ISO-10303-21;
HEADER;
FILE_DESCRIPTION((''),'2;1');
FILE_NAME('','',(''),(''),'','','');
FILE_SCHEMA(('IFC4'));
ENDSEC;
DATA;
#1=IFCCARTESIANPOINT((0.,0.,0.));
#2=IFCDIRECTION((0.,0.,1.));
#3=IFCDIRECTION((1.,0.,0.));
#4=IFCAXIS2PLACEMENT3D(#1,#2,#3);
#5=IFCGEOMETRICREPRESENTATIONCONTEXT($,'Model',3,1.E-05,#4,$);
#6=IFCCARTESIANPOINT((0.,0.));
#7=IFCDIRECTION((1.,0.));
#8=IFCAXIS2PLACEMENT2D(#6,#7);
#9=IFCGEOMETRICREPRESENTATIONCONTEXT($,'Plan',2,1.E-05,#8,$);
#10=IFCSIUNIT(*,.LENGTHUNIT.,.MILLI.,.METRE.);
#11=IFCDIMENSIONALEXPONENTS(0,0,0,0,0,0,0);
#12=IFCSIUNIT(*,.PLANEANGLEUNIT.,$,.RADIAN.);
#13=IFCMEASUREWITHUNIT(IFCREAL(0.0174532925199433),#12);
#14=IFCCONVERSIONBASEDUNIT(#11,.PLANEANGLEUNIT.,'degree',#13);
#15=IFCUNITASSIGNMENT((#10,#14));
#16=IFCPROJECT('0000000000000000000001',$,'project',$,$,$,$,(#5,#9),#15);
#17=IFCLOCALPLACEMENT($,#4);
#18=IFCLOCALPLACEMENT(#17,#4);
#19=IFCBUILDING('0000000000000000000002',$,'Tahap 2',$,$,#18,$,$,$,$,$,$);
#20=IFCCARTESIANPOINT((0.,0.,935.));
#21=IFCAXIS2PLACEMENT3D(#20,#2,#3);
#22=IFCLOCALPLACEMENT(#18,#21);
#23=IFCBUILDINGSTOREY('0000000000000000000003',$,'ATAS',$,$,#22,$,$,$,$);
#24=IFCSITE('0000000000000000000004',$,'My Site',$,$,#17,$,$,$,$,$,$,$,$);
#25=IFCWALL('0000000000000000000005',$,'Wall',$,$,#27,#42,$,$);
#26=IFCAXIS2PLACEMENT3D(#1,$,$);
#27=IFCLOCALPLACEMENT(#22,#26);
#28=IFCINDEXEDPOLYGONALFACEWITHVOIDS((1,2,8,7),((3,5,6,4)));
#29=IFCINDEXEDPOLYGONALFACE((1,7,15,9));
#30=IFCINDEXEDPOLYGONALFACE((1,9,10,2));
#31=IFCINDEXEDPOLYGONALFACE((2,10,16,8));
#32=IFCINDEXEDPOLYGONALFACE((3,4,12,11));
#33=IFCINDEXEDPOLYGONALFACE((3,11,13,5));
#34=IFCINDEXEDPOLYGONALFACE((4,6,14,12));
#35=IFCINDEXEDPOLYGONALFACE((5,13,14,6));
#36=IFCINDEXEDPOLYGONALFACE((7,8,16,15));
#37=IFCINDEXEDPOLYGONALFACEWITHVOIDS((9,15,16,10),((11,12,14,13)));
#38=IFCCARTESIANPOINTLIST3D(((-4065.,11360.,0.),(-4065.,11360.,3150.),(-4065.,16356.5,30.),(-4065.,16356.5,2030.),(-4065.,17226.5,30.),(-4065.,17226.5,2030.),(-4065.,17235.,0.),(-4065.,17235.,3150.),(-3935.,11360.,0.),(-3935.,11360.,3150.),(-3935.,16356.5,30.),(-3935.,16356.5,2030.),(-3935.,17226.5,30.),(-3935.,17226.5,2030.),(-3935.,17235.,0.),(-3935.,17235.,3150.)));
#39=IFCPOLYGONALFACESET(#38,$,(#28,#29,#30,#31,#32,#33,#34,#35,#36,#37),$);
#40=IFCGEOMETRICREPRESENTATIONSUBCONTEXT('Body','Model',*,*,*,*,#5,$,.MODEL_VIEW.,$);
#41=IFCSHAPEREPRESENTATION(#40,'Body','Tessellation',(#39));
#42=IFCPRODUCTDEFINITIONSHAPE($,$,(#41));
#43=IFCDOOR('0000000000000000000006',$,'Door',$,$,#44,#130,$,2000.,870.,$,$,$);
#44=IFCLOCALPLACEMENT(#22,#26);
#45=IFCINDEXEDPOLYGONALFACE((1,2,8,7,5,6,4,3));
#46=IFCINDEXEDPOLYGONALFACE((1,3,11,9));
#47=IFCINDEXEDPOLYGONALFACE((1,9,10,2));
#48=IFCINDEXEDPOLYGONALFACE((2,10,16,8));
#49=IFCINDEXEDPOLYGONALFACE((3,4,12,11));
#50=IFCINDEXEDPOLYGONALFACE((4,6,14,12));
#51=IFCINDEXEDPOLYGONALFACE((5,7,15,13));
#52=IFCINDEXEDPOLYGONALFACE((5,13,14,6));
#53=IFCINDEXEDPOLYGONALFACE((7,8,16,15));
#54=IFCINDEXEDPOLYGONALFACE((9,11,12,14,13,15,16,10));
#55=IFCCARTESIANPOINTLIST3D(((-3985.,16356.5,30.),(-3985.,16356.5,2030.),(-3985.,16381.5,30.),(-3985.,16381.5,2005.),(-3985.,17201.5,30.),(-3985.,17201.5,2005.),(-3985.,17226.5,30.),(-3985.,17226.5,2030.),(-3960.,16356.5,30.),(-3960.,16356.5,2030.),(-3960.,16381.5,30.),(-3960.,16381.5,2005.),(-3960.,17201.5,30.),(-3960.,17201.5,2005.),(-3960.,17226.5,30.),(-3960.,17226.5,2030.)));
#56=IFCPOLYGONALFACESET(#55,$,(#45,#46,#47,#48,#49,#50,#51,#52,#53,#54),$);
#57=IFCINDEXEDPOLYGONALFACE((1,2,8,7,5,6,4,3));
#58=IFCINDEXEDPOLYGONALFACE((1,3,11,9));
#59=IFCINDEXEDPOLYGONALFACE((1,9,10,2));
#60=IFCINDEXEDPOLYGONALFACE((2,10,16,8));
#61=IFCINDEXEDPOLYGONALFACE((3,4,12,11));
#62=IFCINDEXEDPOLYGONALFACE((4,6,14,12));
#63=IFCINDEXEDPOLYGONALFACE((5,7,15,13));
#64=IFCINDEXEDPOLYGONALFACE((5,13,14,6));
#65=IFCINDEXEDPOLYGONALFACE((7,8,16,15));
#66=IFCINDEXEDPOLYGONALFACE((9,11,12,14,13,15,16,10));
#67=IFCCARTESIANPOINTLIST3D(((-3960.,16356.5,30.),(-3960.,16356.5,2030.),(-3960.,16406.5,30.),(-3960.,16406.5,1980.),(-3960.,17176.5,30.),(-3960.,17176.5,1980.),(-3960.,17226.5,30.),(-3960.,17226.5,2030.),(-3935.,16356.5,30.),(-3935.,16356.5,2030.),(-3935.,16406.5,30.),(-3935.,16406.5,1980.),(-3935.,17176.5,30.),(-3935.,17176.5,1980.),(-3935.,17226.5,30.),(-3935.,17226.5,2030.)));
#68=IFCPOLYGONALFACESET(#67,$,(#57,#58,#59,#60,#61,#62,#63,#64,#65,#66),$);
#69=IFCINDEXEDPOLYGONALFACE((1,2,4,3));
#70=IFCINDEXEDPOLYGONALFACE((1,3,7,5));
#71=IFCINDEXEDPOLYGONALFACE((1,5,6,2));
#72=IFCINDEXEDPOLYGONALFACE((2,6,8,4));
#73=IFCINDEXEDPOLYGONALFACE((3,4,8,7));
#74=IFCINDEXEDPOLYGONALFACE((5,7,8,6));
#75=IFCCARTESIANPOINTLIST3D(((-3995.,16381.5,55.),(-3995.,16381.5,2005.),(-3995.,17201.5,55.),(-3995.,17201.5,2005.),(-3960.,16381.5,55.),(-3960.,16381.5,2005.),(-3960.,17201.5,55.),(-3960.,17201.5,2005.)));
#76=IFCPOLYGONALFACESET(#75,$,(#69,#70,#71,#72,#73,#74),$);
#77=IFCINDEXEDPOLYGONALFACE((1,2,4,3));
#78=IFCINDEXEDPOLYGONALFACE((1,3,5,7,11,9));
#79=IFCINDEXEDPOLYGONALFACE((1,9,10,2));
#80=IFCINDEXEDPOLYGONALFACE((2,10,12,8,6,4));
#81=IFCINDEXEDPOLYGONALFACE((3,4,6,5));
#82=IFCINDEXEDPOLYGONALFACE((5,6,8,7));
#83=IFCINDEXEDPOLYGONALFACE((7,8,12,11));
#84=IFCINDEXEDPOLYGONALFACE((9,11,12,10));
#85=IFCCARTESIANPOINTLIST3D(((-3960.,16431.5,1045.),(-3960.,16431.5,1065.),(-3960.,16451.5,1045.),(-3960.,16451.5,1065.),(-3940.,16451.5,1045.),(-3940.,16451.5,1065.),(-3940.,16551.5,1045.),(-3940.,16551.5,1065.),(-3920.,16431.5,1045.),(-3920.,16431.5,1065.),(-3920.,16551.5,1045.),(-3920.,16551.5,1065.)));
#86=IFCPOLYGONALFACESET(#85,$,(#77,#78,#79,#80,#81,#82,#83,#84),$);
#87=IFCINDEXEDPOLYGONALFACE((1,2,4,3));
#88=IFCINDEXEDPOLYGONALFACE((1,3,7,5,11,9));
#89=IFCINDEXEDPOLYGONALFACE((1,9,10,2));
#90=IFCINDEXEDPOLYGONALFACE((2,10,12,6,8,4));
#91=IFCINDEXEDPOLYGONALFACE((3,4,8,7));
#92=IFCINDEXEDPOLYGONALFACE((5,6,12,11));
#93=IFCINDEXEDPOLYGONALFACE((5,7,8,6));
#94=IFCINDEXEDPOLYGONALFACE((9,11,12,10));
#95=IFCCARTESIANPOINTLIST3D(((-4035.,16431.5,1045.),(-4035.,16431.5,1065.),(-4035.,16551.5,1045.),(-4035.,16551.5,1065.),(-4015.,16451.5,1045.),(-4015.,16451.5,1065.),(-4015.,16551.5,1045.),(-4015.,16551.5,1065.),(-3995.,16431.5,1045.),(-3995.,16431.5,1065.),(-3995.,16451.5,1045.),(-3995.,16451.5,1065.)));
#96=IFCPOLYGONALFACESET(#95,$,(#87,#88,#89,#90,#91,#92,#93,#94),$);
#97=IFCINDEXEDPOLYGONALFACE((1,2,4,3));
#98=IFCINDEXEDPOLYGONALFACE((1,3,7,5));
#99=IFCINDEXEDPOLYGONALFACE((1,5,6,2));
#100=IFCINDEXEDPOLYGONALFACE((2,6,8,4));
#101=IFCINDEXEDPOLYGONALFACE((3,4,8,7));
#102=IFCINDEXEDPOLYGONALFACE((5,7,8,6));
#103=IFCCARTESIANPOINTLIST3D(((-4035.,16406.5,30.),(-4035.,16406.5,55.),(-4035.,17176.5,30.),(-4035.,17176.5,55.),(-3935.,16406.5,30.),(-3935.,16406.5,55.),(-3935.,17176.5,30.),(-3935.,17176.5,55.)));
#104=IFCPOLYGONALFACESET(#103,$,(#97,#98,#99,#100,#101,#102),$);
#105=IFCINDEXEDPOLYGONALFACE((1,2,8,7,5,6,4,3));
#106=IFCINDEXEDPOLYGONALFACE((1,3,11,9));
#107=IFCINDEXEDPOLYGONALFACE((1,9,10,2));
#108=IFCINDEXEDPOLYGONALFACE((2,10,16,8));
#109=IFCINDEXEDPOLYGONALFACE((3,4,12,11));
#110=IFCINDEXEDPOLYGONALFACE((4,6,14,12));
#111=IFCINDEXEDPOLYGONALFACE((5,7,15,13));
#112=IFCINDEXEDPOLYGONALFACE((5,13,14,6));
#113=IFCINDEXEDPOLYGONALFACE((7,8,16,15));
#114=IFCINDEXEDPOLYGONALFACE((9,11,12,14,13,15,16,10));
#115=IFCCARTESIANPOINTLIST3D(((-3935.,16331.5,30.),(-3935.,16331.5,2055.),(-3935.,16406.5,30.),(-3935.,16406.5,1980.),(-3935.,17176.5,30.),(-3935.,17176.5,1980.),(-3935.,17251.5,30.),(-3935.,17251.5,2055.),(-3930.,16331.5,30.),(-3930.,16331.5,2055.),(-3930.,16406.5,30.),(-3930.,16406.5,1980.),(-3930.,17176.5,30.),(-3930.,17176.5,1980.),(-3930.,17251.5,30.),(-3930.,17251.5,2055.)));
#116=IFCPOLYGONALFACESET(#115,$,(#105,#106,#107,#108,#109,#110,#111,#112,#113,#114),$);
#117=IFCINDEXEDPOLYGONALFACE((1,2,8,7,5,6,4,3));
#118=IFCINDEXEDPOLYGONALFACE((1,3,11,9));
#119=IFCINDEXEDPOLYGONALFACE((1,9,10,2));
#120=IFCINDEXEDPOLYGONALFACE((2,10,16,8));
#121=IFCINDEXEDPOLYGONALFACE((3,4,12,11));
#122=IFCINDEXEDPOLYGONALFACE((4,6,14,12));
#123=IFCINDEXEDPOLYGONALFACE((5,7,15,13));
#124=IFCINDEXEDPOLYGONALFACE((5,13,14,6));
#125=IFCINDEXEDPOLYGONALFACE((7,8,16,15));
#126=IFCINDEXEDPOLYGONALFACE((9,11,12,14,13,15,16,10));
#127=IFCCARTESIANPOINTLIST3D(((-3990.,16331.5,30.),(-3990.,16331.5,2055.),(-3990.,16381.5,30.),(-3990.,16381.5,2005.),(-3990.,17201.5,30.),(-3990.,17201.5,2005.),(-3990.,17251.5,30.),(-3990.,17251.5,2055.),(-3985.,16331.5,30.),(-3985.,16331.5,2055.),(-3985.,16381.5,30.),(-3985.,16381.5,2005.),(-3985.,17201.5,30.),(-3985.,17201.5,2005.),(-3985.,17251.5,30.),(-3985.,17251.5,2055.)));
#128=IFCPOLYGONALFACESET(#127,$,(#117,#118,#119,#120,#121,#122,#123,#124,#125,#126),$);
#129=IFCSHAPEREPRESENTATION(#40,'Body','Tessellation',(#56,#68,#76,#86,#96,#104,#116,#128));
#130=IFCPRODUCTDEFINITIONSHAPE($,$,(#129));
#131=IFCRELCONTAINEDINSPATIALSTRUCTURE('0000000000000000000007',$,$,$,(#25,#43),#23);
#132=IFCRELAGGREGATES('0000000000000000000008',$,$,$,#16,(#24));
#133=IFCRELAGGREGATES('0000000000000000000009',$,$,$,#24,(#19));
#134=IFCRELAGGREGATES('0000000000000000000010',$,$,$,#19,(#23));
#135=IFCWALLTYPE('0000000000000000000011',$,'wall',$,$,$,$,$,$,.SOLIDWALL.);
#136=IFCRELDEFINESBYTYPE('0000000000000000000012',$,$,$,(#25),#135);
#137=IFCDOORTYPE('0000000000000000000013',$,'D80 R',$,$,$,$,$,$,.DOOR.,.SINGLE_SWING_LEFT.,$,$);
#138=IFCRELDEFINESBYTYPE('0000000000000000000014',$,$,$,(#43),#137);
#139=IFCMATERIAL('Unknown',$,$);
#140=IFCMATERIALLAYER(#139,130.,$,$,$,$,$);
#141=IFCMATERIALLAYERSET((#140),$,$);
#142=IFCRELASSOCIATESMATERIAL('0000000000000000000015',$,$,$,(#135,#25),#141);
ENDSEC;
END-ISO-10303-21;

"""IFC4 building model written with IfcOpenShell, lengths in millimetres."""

from ifc_helpers import new_model, entity, si_unit, converted_unit, frame, origin_with_axes, origin_2d_with_axis, place, context, subcontext, project, spatial, line, indexed_curve, outline, extrude, shape, source, transform, mapped, material, layer, layer_set, layer_usage, type_object, type_shapes, element, fill, save


model = new_model("IFC4")

# Units and contexts
model_context = context("Model", 3, precision=1e-05, world=origin_with_axes())
plan_context = context("Plan", 2, precision=1e-05, world=origin_2d_with_axis())
body_context_1 = subcontext(model_context, "Body", "Model", "MODEL_VIEW")
body_context_2 = subcontext(plan_context, "Body", "Plan", "PLAN_VIEW")
ifc_project = project(units=[si_unit("LENGTHUNIT", "METRE", prefix="MILLI"), converted_unit("PLANEANGLEUNIT", "degree", entity("IfcReal", 0.0174532925199433), si_unit("PLANEANGLEUNIT", "RADIAN"), dimensions=[0, 0, 0, 0, 0, 0, 0])], contexts=[model_context, plan_context])

# Site, building, storey
site_placement = place(None, origin_with_axes())
site = spatial("IfcSite", under=ifc_project, at=site_placement, Name="My Site")
building_placement = place(site_placement, origin_with_axes())
building = spatial("IfcBuilding", under=site, at=building_placement, Name="Tahap 2")
storey_placement = place(building_placement, frame((0.0, 0.0, 935.0), z_axis=(0.0, 0.0, 1.0), x_axis=(1.0, 0.0, 0.0)))
storey = spatial("IfcBuildingStorey", under=building, at=storey_placement, Name="ATAS")

# Wall, opening, door
ifc_material_1 = material(Name="Unknown")
ifc_layer_1 = layer(ifc_material_1, 130.0)
ifc_layer_set_1 = layer_set([ifc_layer_1])
ifc_layer_usage_1 = layer_usage(ifc_layer_set_1, "AXIS2", "POSITIVE", 0.0)
wall_type_1 = type_object("IfcWallType", Name="wall", PredefinedType="SOLIDWALL", material=ifc_layer_set_1)
wall_1_placement = place(storey_placement, frame((-3935.0, 11360.0, 0.0), z_axis=(0.0, 0.0, 1.0), x_axis=(0.0, 1.0, 0.0)))
wall_1 = element("IfcWall", 1, at=wall_1_placement, inside=storey, type_object=wall_type_1, material=ifc_layer_usage_1, Name="Wall", context=body_context_1, shape_type="SweptSolid", body=[
    extrude(outline(indexed_curve([(0.0, 0.0), (0.0, 130.0), (5875.0, 130.0), (5875.0, 0.0)], segments=[line(1, 2, 3, 4, 1)])), origin_with_axes(), (0.0, 0.0, 1.0), 3150.0),
])
shared_shape_1 = source(origin_with_axes(), body_context_1, "Body", "SweptSolid", [
    extrude(outline(indexed_curve([(0.0, 0.0), (870.0, 0.0), (870.0, 2000.0), (0.0, 2000.0)], segments=[line(1, 2, 3, 4, 1)])), frame((0.0, -600.0, 0.0), z_axis=(0.0, -1.0, 0.0), x_axis=(1.0, 0.0, 0.0)), (0.0, 0.0, -1.0), 1200.0),
])
opening_1_placement = place(wall_1_placement, frame((4996.5, 0.0, 30.0), z_axis=(0.0, 0.0, 1.0), x_axis=(1.0, 0.0, 0.0)))
opening_1 = element("IfcOpeningElement", 2, at=opening_1_placement, cuts=wall_1, PredefinedType="OPENING", context=body_context_1, shape_type="MappedRepresentation", body=[
    mapped(shared_shape_1, transform((0.0, 0.0, 0.0), x_axis=(1.0, 0.0, 0.0), y_axis=(0.0, 1.0, 0.0), z_axis=(0.0, 0.0, 1.0), scale=1.0)),
])
door_type_1 = type_object("IfcDoorType", Name="D80 R", OperationType="SINGLE_SWING_LEFT", PredefinedType="DOOR")
shared_shape_2 = source(origin_with_axes(), body_context_1, "Body", "SweptSolid", [
    extrude(outline(indexed_curve([(0.0, 0.0), (0.0, 2000.0), (870.0, 2000.0), (870.0, 0.0), (845.0, 0.0), (845.0, 1975.0), (25.0, 1975.0), (25.0, 0.0)], segments=[line(1, 2, 3, 4, 5, 6, 7, 8, 1)])), frame((0.0, 25.0, 0.0), z_axis=(0.0, -1.0, 0.0), x_axis=(1.0, 0.0, 0.0)), (0.0, 0.0, -1.0), 25.0),
    extrude(outline(indexed_curve([(0.0, 0.0), (0.0, 2000.0), (870.0, 2000.0), (870.0, 0.0), (820.0, 0.0), (820.0, 1950.0), (50.0, 1950.0), (50.0, 0.0)], segments=[line(1, 2, 3, 4, 5, 6, 7, 8, 1)])), frame((0.0, 0.0, 0.0), z_axis=(0.0, -1.0, 0.0), x_axis=(1.0, 0.0, 0.0)), (0.0, 0.0, -1.0), 25.0),
    extrude(outline(indexed_curve([(0.0, 0.0), (820.0, 0.0), (820.0, 35.0), (0.0, 35.0)], segments=[line(1, 2, 3, 4, 1)])), frame((25.0, 25.0, 25.0), z_axis=(0.0, 0.0, 1.0), x_axis=(1.0, 0.0, 0.0)), (0.0, 0.0, 1.0), 1950.0),
    extrude(outline(indexed_curve([(0.0, 0.0), (0.0, -40.0), (120.0, -40.0), (120.0, -20.0), (20.0, -20.0), (20.0, 0.0)], segments=[line(1, 2, 3, 4, 5, 6, 1)])), frame((75.0, 25.0, 1015.0), z_axis=(0.0, 0.0, 1.0), x_axis=(1.0, 0.0, 0.0)), (0.0, 0.0, 1.0), 20.0),
    extrude(outline(indexed_curve([(0.0, 0.0), (0.0, 40.0), (120.0, 40.0), (120.0, 20.0), (20.0, 20.0), (20.0, 0.0)], segments=[line(1, 2, 3, 4, 5, 6, 1)])), frame((75.0, 60.0, 1015.0), z_axis=(0.0, 0.0, 1.0), x_axis=(1.0, 0.0, 0.0)), (0.0, 0.0, 1.0), 20.0),
    extrude(outline(indexed_curve([(0.0, 0.0), (770.0, 0.0), (770.0, 100.0), (0.0, 100.0)], segments=[line(1, 2, 3, 4, 1)])), frame((50.0, 0.0, 0.0), z_axis=(0.0, 0.0, 1.0), x_axis=(1.0, 0.0, 0.0)), (0.0, 0.0, 1.0), 25.0),
    extrude(outline(indexed_curve([(0.0, 0.0), (0.0, 2025.0), (920.0, 2025.0), (920.0, 0.0), (845.0, 0.0), (845.0, 1950.0), (75.0, 1950.0), (75.0, 0.0)], segments=[line(1, 2, 3, 4, 5, 6, 7, 8, 1)])), frame((-25.0, -5.0, 0.0), z_axis=(0.0, -1.0, 0.0), x_axis=(1.0, 0.0, 0.0)), (0.0, 0.0, -1.0), 5.0),
    extrude(outline(indexed_curve([(0.0, 0.0), (0.0, 2025.0), (920.0, 2025.0), (920.0, 0.0), (870.0, 0.0), (870.0, 1975.0), (50.0, 1975.0), (50.0, 0.0)], segments=[line(1, 2, 3, 4, 5, 6, 7, 8, 1)])), frame((-25.0, 50.0, 0.0), z_axis=(0.0, -1.0, 0.0), x_axis=(1.0, 0.0, 0.0)), (0.0, 0.0, -1.0), 5.0),
])
shared_shape_3 = source(origin_with_axes(), body_context_2, "Body", "Curve2D", [
    entity("IfcIndexedPolyCurve", entity("IfcCartesianPointList2D", [[0.0, 0.0], [0.0, 50.0], [25.0, 50.0], [25.0, 25.0], [50.0, 25.0], [50.0, 0.0]]), [entity("IfcLineIndex", [1, 2, 3, 4, 5, 6, 1])]),
    entity("IfcIndexedPolyCurve", entity("IfcCartesianPointList2D", [[870.0, 0.0], [870.0, 50.0], [845.0, 50.0], [845.0, 25.0], [820.0, 25.0], [820.0, 0.0]]), [entity("IfcLineIndex", [1, 2, 3, 4, 5, 6, 1])]),
    entity("IfcTrimmedCurve", entity("IfcEllipse", entity("IfcAxis2Placement2D", entity("IfcCartesianPoint", [810.0, 50.0]), entity("IfcDirection", [1.0, 0.0])), 785.0, 820.0), [entity("IfcCartesianPoint", [810.0, 870.0])], [entity("IfcCartesianPoint", [25.0, 50.0])], True, "CARTESIAN"),
    entity("IfcIndexedPolyCurve", entity("IfcCartesianPointList2D", [[845.0, 50.0], [810.0, 50.0], [810.0, 870.0], [845.0, 870.0]]), [entity("IfcLineIndex", [1, 2, 3, 4, 1])]),
])
type_shapes(door_type_1, [shared_shape_2, shared_shape_3])
door_1_placement = place(opening_1_placement, frame((0.0, 0.0, 0.0), z_axis=(0.0, 0.0, 1.0), x_axis=(1.0, 0.0, 0.0)))
door_1 = element("IfcDoor", 3, at=door_1_placement, inside=storey, type_object=door_type_1, Name="Door", OverallHeight=2000.0, OverallWidth=870.0, shapes=[
    shape(body_context_1, "Body", "MappedRepresentation", [mapped(shared_shape_2, transform((0.0, 0.0, 0.0), x_axis=(1.0, 0.0, 0.0), y_axis=(0.0, 1.0, 0.0), z_axis=(0.0, 0.0, 1.0), scale=1.0))]),
    shape(body_context_2, "Body", "MappedRepresentation", [mapped(shared_shape_3, transform((0.0, 0.0, 0.0), x_axis=(1.0, 0.0, 0.0), y_axis=(0.0, 1.0, 0.0), z_axis=(0.0, 0.0, 1.0), scale=1.0))]),
])
fill(opening_1, door_1)

save(model, "model.ifc")
